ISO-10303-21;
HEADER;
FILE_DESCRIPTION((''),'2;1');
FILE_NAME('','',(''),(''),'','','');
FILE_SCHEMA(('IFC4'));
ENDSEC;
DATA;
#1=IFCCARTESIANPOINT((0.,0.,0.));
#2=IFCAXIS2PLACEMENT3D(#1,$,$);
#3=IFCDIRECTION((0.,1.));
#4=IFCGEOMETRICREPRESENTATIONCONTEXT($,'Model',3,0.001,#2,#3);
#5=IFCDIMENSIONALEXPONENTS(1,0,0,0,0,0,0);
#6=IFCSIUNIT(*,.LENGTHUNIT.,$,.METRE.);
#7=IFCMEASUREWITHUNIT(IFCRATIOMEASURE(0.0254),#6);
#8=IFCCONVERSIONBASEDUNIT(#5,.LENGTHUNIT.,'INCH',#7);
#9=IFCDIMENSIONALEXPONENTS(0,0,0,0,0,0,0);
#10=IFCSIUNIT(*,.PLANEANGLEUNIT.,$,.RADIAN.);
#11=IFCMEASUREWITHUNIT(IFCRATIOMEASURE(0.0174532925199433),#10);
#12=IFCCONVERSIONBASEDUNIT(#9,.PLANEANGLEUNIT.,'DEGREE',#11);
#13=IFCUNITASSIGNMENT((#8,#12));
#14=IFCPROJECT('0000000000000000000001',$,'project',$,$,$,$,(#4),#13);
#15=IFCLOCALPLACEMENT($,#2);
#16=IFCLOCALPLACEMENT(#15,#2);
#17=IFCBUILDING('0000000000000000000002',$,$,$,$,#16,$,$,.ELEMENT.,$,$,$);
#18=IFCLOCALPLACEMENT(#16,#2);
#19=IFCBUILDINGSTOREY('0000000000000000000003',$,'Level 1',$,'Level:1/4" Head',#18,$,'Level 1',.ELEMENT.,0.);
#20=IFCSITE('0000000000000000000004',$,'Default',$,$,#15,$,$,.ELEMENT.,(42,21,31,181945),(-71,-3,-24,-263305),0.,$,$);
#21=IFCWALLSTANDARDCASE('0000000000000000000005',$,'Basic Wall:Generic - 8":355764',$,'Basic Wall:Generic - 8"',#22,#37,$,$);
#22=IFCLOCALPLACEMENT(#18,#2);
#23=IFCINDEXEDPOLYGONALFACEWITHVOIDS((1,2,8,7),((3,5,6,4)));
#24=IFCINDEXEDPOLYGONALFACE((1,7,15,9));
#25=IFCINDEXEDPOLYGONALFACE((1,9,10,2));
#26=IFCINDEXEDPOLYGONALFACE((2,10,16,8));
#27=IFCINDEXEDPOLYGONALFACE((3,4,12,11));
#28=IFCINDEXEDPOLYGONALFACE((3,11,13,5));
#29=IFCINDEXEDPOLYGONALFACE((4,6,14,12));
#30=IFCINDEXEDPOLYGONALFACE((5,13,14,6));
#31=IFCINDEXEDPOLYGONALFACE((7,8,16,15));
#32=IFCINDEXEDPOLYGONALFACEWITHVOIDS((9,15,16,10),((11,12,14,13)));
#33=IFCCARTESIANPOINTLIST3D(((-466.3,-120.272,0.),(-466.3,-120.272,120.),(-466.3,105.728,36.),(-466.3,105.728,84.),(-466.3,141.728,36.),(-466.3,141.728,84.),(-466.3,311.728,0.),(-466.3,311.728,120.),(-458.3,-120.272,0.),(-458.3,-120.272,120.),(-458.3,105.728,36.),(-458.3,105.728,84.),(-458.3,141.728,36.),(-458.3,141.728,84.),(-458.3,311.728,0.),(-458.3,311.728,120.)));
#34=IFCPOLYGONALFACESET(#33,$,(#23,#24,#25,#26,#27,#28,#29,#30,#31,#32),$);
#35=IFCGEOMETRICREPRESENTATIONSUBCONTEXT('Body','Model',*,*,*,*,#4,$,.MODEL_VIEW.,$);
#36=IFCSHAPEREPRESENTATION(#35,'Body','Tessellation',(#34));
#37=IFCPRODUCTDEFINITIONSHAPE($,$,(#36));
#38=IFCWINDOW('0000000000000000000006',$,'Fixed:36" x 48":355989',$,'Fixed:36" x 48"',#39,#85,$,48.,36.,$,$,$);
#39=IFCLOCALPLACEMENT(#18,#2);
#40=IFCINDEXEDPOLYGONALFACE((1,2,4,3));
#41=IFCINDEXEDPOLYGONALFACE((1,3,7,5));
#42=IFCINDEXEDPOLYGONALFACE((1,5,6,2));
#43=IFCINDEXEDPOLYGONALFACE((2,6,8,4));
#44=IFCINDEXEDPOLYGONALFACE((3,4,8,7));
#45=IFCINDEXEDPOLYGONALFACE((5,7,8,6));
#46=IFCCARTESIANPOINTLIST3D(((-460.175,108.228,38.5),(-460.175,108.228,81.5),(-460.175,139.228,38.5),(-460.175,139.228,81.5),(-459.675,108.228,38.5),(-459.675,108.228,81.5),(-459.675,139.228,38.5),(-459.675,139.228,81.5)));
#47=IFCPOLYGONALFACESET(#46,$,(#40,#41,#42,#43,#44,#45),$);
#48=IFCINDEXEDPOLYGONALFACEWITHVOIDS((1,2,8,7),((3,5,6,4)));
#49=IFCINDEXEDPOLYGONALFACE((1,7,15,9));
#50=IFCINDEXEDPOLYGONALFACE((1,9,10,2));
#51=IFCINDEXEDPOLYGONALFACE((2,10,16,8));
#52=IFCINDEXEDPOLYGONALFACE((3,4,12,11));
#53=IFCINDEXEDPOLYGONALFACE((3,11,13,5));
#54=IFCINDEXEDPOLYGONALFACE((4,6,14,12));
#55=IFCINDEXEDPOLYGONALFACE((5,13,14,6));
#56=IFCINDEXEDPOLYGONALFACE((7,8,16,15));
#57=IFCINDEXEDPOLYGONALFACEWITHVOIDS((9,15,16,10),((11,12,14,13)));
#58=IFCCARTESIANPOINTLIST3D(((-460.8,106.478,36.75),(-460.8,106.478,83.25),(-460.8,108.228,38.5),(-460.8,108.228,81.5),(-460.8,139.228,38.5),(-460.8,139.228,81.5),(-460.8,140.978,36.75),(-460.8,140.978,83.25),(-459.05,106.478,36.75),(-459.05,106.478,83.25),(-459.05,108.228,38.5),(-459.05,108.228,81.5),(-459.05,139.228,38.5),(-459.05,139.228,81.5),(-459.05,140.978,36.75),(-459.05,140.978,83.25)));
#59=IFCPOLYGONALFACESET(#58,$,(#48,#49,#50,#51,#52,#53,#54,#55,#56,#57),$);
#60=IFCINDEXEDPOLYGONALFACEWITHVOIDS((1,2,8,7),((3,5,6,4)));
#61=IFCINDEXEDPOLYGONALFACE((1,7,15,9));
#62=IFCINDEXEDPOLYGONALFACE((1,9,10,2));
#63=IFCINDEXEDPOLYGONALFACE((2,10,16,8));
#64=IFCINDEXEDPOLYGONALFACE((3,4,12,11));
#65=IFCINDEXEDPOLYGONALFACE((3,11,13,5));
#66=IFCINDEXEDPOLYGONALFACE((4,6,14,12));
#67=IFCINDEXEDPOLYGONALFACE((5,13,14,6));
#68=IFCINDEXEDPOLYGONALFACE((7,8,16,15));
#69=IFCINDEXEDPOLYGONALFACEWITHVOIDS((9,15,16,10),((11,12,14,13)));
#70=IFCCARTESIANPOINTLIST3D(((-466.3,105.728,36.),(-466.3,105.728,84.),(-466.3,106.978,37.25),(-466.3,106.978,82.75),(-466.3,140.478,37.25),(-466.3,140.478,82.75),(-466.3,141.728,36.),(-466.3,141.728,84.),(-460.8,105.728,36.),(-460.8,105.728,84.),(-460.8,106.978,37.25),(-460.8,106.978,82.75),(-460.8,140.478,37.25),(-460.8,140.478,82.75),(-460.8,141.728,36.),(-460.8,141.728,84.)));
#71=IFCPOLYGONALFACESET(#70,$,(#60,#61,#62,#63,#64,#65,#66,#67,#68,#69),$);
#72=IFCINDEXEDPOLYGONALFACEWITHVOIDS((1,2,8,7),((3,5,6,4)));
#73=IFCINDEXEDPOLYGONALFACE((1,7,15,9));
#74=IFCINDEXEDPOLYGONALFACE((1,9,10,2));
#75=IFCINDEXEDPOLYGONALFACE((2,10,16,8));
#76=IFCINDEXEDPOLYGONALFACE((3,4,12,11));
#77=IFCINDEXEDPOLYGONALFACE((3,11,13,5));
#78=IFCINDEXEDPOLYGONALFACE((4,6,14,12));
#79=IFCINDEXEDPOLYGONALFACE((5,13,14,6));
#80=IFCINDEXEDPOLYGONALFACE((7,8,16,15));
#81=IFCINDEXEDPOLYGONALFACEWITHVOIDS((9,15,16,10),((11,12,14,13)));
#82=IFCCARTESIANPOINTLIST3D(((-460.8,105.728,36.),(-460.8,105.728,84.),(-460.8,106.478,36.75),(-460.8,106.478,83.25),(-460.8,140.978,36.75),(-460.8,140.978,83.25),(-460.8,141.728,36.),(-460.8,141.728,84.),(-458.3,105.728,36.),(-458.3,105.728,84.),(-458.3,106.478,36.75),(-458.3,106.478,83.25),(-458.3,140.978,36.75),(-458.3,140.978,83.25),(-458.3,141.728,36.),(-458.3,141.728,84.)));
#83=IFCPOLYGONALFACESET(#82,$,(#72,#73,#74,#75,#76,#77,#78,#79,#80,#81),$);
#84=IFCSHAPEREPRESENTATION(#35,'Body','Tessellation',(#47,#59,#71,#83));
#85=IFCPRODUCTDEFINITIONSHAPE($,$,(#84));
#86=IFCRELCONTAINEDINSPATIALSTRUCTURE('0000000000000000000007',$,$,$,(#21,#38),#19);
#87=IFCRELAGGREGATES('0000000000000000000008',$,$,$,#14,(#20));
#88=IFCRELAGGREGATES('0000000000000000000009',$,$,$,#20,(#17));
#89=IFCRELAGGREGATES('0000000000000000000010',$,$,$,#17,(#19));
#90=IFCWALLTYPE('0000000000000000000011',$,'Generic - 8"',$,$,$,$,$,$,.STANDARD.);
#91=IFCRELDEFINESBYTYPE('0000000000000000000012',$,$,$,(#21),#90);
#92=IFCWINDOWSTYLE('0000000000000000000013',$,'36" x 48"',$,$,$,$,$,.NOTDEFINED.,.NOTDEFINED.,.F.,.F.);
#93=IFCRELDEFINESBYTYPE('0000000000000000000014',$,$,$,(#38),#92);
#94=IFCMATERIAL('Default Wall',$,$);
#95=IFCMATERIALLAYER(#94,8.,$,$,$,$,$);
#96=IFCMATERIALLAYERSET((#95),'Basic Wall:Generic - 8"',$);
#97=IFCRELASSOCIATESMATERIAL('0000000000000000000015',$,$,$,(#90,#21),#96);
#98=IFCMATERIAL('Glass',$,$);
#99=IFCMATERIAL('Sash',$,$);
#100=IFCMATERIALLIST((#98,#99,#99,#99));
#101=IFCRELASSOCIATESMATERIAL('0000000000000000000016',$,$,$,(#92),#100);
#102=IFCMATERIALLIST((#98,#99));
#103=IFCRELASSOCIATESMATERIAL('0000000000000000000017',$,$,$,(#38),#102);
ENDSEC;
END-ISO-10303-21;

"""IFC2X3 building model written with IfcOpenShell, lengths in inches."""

from ifc_helpers import new_model, entity, si_unit, converted_unit, direction, frame, frame_2d, origin, place, context, subcontext, project, spatial, polyline, rectangle, outline, extrude, source, transform, mapped, material, material_list, layer, layer_set, layer_usage, type_object, type_shapes, element, fill, save


model = new_model("IFC2X3")

# Units and contexts
model_context = context("Model", 3, precision=0.001, world=origin(), true_north=direction((0.0, 1.0)))
body_context = subcontext(model_context, "Body", "Model", "MODEL_VIEW")
ifc_project = project(units=[converted_unit("LENGTHUNIT", "INCH", entity("IfcRatioMeasure", 0.0254), si_unit("LENGTHUNIT", "METRE"), dimensions=[1, 0, 0, 0, 0, 0, 0]), converted_unit("PLANEANGLEUNIT", "DEGREE", entity("IfcRatioMeasure", 0.0174532925199433), si_unit("PLANEANGLEUNIT", "RADIAN"), dimensions=[0, 0, 0, 0, 0, 0, 0])], contexts=[model_context])

# Site, building, storey
site_placement = place(None, origin())
site = spatial("IfcSite", under=ifc_project, at=site_placement, Name="Default", CompositionType="ELEMENT", RefLatitude=(42, 21, 31, 181945), RefLongitude=(-71, -3, -24, -263305), RefElevation=0.0)
building_placement = place(site_placement, origin())
building = spatial("IfcBuilding", under=site, at=building_placement, CompositionType="ELEMENT")
storey_placement = place(building_placement, origin())
storey = spatial("IfcBuildingStorey", under=building, at=storey_placement, Name="Level 1", ObjectType="Level:1/4\" Head", LongName="Level 1", CompositionType="ELEMENT", Elevation=0.0)

# Shared definitions
ifc_material_1 = material(Name="Default Wall")
ifc_layer_1 = layer(ifc_material_1, 8.0)
ifc_layer_set_1 = layer_set([ifc_layer_1], Name="Basic Wall:Generic - 8\"")
wall_type_1 = type_object("IfcWallType", Name="Generic - 8\"", PredefinedType="STANDARD", material=ifc_layer_set_1)
ifc_material_2 = material(Name="Glass")
ifc_material_3 = material(Name="Sash")
ifc_material_list_1 = material_list([ifc_material_2, ifc_material_3, ifc_material_3, ifc_material_3])
window_style = type_object("IfcWindowStyle", Name="36\" x 48\"", ConstructionType="NOTDEFINED", OperationType="NOTDEFINED", ParameterTakesPrecedence=False, Sizeable=False, material=ifc_material_list_1)
shared_shape_1 = source(origin(), body_context, "Body", "SweptSolid", [
    extrude(rectangle(XDim=0.5, YDim=31.0, at=frame_2d((0.0, 0.0), x_axis=(1.0, 0.0))), frame((18.0, 6.375, 2.5), z_axis=(0.0, 0.0, 1.0), x_axis=(0.0, 1.0, 0.0)), (0.0, 0.0, 1.0), 43.0),
    extrude(outline(polyline([(-17.25, -23.25), (17.25, -23.25), (17.25, 23.25), (-17.25, 23.25), (-17.25, -23.25)]), holes=[polyline([(-15.5, -21.5), (-15.5, 21.5), (15.5, 21.5), (15.5, -21.5), (-15.5, -21.5)])]), frame((18.0, 5.5, 24.0), z_axis=(0.0, 1.0, 0.0), x_axis=(1.0, 0.0, 0.0)), (0.0, 0.0, 1.0), 1.75),
    extrude(outline(polyline([(-18.0, -24.0), (18.0, -24.0), (18.0, 24.0), (-18.0, 24.0), (-18.0, -24.0)]), holes=[polyline([(-16.75, -22.75), (-16.75, 22.75), (16.75, 22.75), (16.75, -22.75), (-16.75, -22.75)])]), frame((18.0, 0.0, 24.0), z_axis=(0.0, 1.0, 0.0), x_axis=(1.0, 0.0, 0.0)), (0.0, 0.0, 1.0), 5.5),
    extrude(outline(polyline([(-24.0, -18.0), (24.0, -18.0), (24.0, 18.0), (-24.0, 18.0), (-24.0, -18.0)]), holes=[polyline([(-23.25, -17.25), (-23.25, 17.25), (23.25, 17.25), (23.25, -17.25), (-23.25, -17.25)])]), frame((18.0, 5.5, 24.0), z_axis=(0.0, 1.0, 0.0), x_axis=(0.0, 0.0, -1.0)), (0.0, 0.0, 1.0), 2.5),
])
type_shapes(window_style, [shared_shape_1])

# Wall, opening, window
ifc_layer_usage_1 = layer_usage(ifc_layer_set_1, "AXIS2", "NEGATIVE", 4.0)
wall_1_placement = place(storey_placement, frame((-462.3, -120.272, 0.0), z_axis=(0.0, 0.0, 1.0), x_axis=(0.0, 1.0, 0.0)))
wall_1 = element("IfcWallStandardCase", 1, at=wall_1_placement, inside=storey, type_object=wall_type_1, material=ifc_layer_usage_1, Name="Basic Wall:Generic - 8\":355764", ObjectType="Basic Wall:Generic - 8\"", context=body_context, shape_type="SweptSolid", body=[
    extrude(rectangle(XDim=432.0, YDim=8.0, at=frame_2d((216.0, 0.0), x_axis=(-1.0, 0.0))), origin(), (0.0, 0.0, 1.0), 120.0),
])
opening_1_placement = place(wall_1_placement, frame((262.0, 4.0, 36.0)))
opening_1 = element("IfcOpeningElement", 2, at=opening_1_placement, cuts=wall_1, ObjectType="Opening", context=body_context, shape_type="SweptSolid", body=[
    extrude(rectangle(XDim=48.0, YDim=36.0, at=frame_2d((24.0, 18.0), x_axis=(-1.0, 0.0))), frame((0.0, 0.0, 0.0), z_axis=(0.0, -1.0, 0.0), x_axis=(0.0, 0.0, 1.0)), (0.0, 0.0, 1.0), 8.0),
])
ifc_material_list_2 = material_list([ifc_material_2, ifc_material_3])
window_1_placement = place(opening_1_placement, frame((0.0, 0.0, 0.0), z_axis=(0.0, 0.0, 1.0), x_axis=(-1.0, 0.0, 0.0)))
window_1 = element("IfcWindow", 3, at=window_1_placement, inside=storey, type_object=window_style, material=ifc_material_list_2, Name="Fixed:36\" x 48\":355989", ObjectType="Fixed:36\" x 48\"", OverallHeight=48.0, OverallWidth=36.0, context=body_context, shape_type="MappedRepresentation", body=[
    mapped(shared_shape_1, transform((0.0, 0.0, 0.0), scale=1.0)),
])
fill(opening_1, window_1)

save(model, "model.ifc")
